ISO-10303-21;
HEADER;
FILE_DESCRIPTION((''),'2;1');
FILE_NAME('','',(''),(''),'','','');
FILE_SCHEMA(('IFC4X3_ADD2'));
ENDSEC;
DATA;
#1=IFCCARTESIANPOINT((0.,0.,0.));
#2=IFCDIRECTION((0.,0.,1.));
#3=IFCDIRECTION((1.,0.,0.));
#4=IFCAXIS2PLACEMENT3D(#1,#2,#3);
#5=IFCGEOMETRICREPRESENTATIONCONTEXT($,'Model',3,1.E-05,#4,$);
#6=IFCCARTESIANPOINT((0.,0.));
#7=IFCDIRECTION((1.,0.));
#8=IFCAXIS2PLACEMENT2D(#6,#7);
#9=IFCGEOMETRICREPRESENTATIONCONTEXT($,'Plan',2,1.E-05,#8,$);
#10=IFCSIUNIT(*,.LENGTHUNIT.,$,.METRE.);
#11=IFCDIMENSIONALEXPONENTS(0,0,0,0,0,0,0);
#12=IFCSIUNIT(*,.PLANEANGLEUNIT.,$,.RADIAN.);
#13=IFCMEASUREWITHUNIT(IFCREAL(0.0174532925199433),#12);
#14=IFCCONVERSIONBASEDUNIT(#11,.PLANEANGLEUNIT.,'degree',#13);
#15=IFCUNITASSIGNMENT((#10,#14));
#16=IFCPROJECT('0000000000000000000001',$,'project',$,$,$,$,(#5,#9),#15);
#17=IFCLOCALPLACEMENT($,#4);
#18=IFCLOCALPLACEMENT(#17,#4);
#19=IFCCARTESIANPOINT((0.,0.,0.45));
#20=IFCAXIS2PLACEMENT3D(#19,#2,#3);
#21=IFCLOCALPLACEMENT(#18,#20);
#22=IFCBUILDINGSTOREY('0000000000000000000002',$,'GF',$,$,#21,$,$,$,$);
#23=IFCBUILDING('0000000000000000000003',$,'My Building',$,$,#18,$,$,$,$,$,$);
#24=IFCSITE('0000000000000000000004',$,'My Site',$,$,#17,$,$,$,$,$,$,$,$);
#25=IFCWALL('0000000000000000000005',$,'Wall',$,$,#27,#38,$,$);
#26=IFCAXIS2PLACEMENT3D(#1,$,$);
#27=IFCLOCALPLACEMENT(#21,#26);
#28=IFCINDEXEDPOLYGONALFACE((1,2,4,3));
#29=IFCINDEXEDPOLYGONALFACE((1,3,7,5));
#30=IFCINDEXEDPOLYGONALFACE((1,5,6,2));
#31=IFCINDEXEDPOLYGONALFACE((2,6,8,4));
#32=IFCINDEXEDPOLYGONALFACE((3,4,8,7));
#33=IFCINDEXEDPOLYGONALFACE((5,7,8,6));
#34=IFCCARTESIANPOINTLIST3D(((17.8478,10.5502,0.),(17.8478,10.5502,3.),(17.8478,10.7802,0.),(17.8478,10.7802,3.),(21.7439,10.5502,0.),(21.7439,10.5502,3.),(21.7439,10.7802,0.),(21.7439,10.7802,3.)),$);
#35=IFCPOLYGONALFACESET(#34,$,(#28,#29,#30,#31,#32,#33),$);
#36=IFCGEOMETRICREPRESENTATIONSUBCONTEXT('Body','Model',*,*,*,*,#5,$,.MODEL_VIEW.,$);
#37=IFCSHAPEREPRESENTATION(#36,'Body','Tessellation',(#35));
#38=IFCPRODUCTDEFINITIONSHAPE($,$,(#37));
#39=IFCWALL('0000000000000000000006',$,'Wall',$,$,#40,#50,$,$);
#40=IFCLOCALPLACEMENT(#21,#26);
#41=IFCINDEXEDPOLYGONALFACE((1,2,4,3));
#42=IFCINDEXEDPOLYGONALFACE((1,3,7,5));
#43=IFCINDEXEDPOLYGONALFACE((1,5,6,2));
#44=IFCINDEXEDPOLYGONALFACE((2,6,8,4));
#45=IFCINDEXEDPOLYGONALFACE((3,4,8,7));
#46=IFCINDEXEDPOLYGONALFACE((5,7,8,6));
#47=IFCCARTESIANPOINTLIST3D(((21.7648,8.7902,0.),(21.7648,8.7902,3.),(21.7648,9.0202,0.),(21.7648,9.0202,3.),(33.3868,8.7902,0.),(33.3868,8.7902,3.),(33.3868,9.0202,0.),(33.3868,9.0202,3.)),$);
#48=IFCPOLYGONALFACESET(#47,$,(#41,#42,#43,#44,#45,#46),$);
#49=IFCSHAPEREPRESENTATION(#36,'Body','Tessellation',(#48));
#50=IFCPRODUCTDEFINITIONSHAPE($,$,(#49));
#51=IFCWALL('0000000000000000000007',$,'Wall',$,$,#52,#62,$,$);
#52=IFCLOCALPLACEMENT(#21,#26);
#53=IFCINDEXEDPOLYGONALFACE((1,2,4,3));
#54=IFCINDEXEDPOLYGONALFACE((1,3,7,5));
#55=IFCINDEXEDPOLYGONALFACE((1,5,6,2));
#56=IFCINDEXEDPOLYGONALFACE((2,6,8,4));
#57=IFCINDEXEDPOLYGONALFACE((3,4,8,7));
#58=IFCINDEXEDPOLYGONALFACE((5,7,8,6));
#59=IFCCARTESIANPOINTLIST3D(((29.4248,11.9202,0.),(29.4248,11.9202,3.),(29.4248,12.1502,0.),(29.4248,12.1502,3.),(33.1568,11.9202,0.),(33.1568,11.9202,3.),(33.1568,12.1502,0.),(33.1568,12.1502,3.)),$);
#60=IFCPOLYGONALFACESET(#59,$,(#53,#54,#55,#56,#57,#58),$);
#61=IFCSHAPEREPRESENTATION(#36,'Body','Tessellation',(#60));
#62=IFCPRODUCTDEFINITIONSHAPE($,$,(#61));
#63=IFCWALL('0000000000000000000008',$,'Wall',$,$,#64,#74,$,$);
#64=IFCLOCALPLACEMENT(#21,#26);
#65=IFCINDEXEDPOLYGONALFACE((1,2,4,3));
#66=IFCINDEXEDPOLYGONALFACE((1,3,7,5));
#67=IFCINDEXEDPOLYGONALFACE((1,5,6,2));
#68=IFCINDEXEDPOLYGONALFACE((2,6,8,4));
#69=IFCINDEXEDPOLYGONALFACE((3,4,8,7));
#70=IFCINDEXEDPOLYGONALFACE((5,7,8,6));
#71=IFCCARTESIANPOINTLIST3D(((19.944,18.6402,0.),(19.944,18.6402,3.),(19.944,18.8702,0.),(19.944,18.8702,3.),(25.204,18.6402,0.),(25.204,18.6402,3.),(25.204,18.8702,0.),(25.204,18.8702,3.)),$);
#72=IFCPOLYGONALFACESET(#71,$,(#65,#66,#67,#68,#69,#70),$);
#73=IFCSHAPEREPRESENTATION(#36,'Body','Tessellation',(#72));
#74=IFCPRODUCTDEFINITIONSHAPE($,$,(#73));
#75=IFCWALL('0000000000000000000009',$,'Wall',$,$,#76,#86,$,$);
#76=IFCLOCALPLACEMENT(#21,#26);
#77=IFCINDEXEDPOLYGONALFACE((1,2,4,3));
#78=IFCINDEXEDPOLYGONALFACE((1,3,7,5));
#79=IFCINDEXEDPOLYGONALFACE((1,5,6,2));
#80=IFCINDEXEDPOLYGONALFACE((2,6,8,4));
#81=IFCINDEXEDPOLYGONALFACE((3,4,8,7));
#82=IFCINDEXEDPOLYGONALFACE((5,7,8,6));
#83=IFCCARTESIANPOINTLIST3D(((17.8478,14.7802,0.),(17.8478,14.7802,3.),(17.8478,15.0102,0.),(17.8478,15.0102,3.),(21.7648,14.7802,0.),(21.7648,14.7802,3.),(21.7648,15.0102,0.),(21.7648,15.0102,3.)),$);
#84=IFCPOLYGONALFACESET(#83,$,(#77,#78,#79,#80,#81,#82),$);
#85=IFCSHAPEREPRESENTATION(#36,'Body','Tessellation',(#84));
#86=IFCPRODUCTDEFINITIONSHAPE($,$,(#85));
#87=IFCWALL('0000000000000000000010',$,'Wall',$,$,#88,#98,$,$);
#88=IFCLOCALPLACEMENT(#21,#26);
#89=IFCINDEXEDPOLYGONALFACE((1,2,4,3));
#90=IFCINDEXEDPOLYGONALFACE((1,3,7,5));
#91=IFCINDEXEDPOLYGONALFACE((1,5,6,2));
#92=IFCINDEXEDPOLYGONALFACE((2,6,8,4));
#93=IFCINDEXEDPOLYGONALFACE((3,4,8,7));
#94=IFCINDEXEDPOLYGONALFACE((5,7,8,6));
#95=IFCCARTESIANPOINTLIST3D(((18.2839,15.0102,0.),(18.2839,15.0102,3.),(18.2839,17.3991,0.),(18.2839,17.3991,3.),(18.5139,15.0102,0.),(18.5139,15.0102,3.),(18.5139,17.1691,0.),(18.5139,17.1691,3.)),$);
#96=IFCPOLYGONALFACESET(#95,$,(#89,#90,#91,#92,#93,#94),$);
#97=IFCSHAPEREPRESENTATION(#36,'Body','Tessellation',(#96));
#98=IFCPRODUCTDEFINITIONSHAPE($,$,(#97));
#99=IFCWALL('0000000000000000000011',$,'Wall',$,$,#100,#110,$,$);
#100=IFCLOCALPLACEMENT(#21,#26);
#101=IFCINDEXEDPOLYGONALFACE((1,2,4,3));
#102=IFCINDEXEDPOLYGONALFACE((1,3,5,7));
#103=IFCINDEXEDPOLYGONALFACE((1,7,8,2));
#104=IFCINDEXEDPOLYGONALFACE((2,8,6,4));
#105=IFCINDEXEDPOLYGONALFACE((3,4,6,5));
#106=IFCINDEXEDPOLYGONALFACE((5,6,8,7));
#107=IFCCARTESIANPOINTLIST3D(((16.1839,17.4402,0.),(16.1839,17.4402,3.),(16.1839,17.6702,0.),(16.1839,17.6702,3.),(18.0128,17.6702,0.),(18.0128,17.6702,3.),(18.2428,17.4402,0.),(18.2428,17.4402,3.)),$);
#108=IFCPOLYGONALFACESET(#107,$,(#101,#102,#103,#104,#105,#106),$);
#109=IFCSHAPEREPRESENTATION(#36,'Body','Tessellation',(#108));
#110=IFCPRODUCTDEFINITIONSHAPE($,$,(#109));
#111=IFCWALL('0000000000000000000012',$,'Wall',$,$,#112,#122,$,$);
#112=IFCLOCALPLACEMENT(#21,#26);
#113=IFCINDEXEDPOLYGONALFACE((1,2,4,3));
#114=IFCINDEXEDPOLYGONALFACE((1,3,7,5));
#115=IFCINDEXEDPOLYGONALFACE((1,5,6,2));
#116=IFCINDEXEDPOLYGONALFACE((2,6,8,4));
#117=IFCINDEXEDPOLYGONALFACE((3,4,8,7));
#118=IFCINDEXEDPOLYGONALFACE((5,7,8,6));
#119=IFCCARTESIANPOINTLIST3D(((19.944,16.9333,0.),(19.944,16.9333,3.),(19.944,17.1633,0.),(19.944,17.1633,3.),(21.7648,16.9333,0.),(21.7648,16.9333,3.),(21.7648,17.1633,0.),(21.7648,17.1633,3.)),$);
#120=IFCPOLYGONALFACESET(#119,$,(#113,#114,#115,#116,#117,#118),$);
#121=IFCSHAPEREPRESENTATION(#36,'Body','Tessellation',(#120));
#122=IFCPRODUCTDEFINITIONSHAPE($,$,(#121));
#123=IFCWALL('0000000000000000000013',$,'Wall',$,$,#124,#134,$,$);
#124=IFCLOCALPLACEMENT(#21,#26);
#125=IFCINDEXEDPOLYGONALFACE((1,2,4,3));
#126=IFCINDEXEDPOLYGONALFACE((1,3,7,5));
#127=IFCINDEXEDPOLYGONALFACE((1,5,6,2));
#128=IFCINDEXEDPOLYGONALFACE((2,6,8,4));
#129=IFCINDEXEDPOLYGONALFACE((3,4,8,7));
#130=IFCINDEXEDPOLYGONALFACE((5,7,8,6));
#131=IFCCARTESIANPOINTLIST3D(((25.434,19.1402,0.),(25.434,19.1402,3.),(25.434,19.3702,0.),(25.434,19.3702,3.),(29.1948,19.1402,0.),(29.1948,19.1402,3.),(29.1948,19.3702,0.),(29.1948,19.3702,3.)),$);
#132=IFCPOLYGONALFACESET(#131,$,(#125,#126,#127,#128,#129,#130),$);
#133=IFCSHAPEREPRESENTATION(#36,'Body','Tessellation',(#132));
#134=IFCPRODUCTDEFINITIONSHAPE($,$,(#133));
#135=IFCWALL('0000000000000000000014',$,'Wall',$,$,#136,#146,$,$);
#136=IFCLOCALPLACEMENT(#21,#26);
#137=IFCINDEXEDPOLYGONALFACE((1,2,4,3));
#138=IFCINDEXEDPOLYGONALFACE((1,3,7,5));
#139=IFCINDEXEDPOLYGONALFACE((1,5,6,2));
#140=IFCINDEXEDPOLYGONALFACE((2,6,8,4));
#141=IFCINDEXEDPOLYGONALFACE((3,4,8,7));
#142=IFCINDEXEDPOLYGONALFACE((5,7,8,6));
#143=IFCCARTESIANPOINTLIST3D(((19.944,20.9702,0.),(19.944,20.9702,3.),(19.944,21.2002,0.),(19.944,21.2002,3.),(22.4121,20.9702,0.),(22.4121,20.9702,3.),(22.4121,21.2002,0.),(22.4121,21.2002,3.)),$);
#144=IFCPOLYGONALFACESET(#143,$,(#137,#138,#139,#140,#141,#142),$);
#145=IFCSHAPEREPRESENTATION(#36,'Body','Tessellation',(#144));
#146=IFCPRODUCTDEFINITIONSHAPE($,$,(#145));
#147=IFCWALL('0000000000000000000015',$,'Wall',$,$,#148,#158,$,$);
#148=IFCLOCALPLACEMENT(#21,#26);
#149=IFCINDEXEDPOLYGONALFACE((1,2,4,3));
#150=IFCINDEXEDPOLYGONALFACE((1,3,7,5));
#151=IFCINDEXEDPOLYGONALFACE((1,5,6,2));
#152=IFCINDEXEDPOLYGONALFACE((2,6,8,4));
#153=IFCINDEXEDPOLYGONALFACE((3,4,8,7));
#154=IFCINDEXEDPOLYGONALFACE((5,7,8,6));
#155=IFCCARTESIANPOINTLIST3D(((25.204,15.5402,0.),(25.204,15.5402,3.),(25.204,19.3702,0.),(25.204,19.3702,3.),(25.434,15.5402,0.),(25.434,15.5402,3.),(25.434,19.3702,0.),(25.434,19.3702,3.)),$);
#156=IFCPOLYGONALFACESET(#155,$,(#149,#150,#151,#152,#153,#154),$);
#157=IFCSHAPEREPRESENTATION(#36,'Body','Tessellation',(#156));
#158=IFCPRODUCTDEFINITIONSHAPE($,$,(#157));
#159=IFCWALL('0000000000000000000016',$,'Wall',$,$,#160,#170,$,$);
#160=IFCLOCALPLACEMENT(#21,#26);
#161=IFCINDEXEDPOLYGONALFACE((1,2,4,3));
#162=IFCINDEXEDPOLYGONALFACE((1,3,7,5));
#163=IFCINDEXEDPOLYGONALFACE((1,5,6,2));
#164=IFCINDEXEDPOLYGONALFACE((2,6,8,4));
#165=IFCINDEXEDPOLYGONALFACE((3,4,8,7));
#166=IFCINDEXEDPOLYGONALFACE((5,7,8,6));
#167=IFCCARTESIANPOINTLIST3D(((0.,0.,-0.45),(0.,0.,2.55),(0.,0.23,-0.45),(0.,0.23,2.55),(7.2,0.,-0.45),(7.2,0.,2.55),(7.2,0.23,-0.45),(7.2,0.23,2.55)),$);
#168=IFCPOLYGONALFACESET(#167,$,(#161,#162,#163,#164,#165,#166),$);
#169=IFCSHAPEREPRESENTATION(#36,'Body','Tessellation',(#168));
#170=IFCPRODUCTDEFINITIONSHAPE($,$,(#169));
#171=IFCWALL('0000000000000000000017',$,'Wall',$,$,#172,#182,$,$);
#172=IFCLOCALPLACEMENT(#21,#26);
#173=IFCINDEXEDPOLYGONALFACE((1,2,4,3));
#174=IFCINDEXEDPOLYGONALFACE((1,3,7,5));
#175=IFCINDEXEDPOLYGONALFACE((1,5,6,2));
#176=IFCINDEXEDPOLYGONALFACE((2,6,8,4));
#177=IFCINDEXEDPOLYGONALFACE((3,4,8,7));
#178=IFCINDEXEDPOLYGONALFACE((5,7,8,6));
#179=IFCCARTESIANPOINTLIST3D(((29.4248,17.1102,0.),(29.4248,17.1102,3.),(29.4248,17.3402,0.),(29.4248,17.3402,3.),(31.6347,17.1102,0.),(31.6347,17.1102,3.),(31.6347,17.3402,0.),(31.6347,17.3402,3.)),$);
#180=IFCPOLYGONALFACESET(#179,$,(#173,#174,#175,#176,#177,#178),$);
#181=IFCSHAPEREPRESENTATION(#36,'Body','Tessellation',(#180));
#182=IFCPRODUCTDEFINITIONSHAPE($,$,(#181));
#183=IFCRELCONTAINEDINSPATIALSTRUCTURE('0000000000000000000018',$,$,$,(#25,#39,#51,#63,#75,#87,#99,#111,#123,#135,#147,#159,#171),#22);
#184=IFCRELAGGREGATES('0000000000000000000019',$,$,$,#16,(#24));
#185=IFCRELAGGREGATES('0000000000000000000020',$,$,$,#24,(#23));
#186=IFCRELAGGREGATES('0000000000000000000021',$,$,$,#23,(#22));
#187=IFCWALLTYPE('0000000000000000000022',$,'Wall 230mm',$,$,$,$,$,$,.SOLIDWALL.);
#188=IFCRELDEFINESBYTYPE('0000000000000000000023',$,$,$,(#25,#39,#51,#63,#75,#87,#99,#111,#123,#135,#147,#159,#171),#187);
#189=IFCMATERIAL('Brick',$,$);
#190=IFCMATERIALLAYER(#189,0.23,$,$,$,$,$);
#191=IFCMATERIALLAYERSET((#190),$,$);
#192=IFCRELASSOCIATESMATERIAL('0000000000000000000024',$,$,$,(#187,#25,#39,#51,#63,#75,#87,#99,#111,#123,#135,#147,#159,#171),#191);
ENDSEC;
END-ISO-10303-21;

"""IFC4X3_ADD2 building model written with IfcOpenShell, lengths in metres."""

from ifc_helpers import new_model, entity, si_unit, converted_unit, frame, origin_with_axes, origin_2d_with_axis, place, context, subcontext, project, spatial, indexed_curve, outline, extrude, clip, halfspace, material, layer, layer_set, layer_usage, type_object, element, save


model = new_model("IFC4X3_ADD2")

# Units and contexts
model_context = context("Model", 3, precision=1e-05, world=origin_with_axes())
plan_context = context("Plan", 2, precision=1e-05, world=origin_2d_with_axis())
body_context = subcontext(model_context, "Body", "Model", "MODEL_VIEW")
ifc_project = project(units=[si_unit("LENGTHUNIT", "METRE"), converted_unit("PLANEANGLEUNIT", "degree", entity("IfcReal", 0.0174532925199433), si_unit("PLANEANGLEUNIT", "RADIAN"), dimensions=[0, 0, 0, 0, 0, 0, 0])], contexts=[model_context, plan_context])

# Site, building, storey
site_placement = place(None, origin_with_axes())
site = spatial("IfcSite", under=ifc_project, at=site_placement, Name="My Site")
building_placement = place(site_placement, origin_with_axes())
building = spatial("IfcBuilding", under=site, at=building_placement, Name="My Building")
storey_placement = place(building_placement, frame((0.0, 0.0, 0.45), z_axis=(0.0, 0.0, 1.0), x_axis=(1.0, 0.0, 0.0)))
storey = spatial("IfcBuildingStorey", under=building, at=storey_placement, Name="GF")

# Walls
ifc_material_1 = material(Name="Brick")
ifc_layer_1 = layer(ifc_material_1, 0.23)
ifc_layer_set_1 = layer_set([ifc_layer_1])
wall_type_1 = type_object("IfcWallType", Name="Wall 230mm", PredefinedType="SOLIDWALL", material=ifc_layer_set_1)
ifc_layer_usage_1 = layer_usage(ifc_layer_set_1, "AXIS2", "POSITIVE", 0.0)
wall_1_placement = place(storey_placement, frame((21.7439, 10.7802, 0.0), z_axis=(0.0, 0.0, 1.0), x_axis=(-1.0, 0.0, 0.0)))
element("IfcWall", 1, at=wall_1_placement, inside=storey, type_object=wall_type_1, material=ifc_layer_usage_1, Name="Wall", context=body_context, shape_type="SweptSolid", body=[
    extrude(outline(indexed_curve([(0.0, 0.0), (0.0, 0.23), (3.8962, 0.23), (3.8962, 0.0), (0.0, 0.0)], self_intersect=False)), origin_with_axes(), (0.0, 0.0, 1.0), 3.0),
])
ifc_layer_usage_2 = layer_usage(ifc_layer_set_1, "AXIS2", "POSITIVE", 0.0)
wall_2_placement = place(storey_placement, frame((33.3868, 9.0202, 0.0), z_axis=(0.0, 0.0, 1.0), x_axis=(-1.0, 0.0, 0.0)))
element("IfcWall", 2, at=wall_2_placement, inside=storey, type_object=wall_type_1, material=ifc_layer_usage_2, Name="Wall", context=body_context, shape_type="SweptSolid", body=[
    extrude(outline(indexed_curve([(0.0, 0.0), (0.0, 0.23), (11.622, 0.23), (11.622, 0.0), (0.0, 0.0)], self_intersect=False)), origin_with_axes(), (0.0, 0.0, 1.0), 3.0),
])
ifc_layer_usage_3 = layer_usage(ifc_layer_set_1, "AXIS2", "POSITIVE", 0.0)
wall_3_placement = place(storey_placement, frame((33.1568, 12.1502, 0.0), z_axis=(0.0, 0.0, 1.0), x_axis=(-1.0, 0.0, 0.0)))
element("IfcWall", 3, at=wall_3_placement, inside=storey, type_object=wall_type_1, material=ifc_layer_usage_3, Name="Wall", context=body_context, shape_type="SweptSolid", body=[
    extrude(outline(indexed_curve([(0.0, 0.0), (0.0, 0.23), (3.732, 0.23), (3.732, 0.0), (0.0, 0.0)], self_intersect=False)), origin_with_axes(), (0.0, 0.0, 1.0), 3.0),
])
ifc_layer_usage_4 = layer_usage(ifc_layer_set_1, "AXIS2", "POSITIVE", 0.0)
wall_4_placement = place(storey_placement, frame((25.204, 18.8702, 0.0), z_axis=(0.0, 0.0, 1.0), x_axis=(-1.0, 0.0, 0.0)))
element("IfcWall", 4, at=wall_4_placement, inside=storey, type_object=wall_type_1, material=ifc_layer_usage_4, Name="Wall", context=body_context, shape_type="SweptSolid", body=[
    extrude(outline(indexed_curve([(0.0, 0.0), (0.0, 0.23), (5.26, 0.23), (5.26, 0.0), (0.0, 0.0)], self_intersect=False)), origin_with_axes(), (0.0, 0.0, 1.0), 3.0),
])
ifc_layer_usage_5 = layer_usage(ifc_layer_set_1, "AXIS2", "POSITIVE", 0.0)
wall_5_placement = place(storey_placement, frame((21.7648, 15.0102, 0.0), z_axis=(0.0, 0.0, 1.0), x_axis=(-1.0, 0.0, 0.0)))
element("IfcWall", 5, at=wall_5_placement, inside=storey, type_object=wall_type_1, material=ifc_layer_usage_5, Name="Wall", context=body_context, shape_type="SweptSolid", body=[
    extrude(outline(indexed_curve([(0.0, 0.0), (0.0, 0.23), (3.917, 0.23), (3.917, 0.0), (0.0, 0.0)], self_intersect=False)), origin_with_axes(), (0.0, 0.0, 1.0), 3.0),
])
ifc_layer_usage_6 = layer_usage(ifc_layer_set_1, "AXIS2", "POSITIVE", 0.0)
wall_6_placement = place(storey_placement, frame((18.5139, 15.0102, 0.0), z_axis=(0.0, 0.0, 1.0), x_axis=(0.000001, 1.0, 0.0)))
element("IfcWall", 6, at=wall_6_placement, inside=storey, type_object=wall_type_1, material=ifc_layer_usage_6, Name="Wall", context=body_context, shape_type="Clipping", body=[
    clip(extrude(outline(indexed_curve([(0.0, 0.0), (0.0, 0.23), (2.3889, 0.23), (2.3889, 0.0), (0.0, 0.0)], self_intersect=False)), origin_with_axes(), (0.0, 0.0, 1.0), 3.0), halfspace(frame((2.1589, 0.0, 0.0), z_axis=(0.689993, -0.689998, 0.0), x_axis=(-0.707109, -0.707104, 0.0)), False)),
])
ifc_layer_usage_7 = layer_usage(ifc_layer_set_1, "AXIS2", "POSITIVE", 0.0)
wall_7_placement = place(storey_placement, frame((18.2428, 17.6702, 0.0), z_axis=(0.0, 0.0, 1.0), x_axis=(-1.0, 0.0, 0.0)))
element("IfcWall", 7, at=wall_7_placement, inside=storey, type_object=wall_type_1, material=ifc_layer_usage_7, Name="Wall", context=body_context, shape_type="Clipping", body=[
    clip(extrude(outline(indexed_curve([(0.0, 0.0), (0.0, 0.23), (2.0589, 0.23), (2.0589, 0.0), (0.0, 0.0)], self_intersect=False)), origin_with_axes(), (0.0, 0.0, 1.0), 3.0), halfspace(frame((0.23, 0.0, 0.0), z_axis=(-0.689993, -0.689999, 0.0), x_axis=(-0.70711, 0.707104, 0.0)), False)),
])
ifc_layer_usage_8 = layer_usage(ifc_layer_set_1, "AXIS2", "POSITIVE", 0.0)
wall_8_placement = place(storey_placement, frame((21.7648, 17.1633, 0.0), z_axis=(0.0, 0.0, 1.0), x_axis=(-1.0, 0.0, 0.0)))
element("IfcWall", 8, at=wall_8_placement, inside=storey, type_object=wall_type_1, material=ifc_layer_usage_8, Name="Wall", context=body_context, shape_type="SweptSolid", body=[
    extrude(outline(indexed_curve([(0.0, 0.0), (0.0, 0.23), (1.8208, 0.23), (1.8208, 0.0), (0.0, 0.0)], self_intersect=False)), origin_with_axes(), (0.0, 0.0, 1.0), 3.0),
])
ifc_layer_usage_9 = layer_usage(ifc_layer_set_1, "AXIS2", "POSITIVE", 0.0)
wall_9_placement = place(storey_placement, frame((29.1948, 19.3702, 0.0), z_axis=(0.0, 0.0, 1.0), x_axis=(-1.0, 0.0, 0.0)))
element("IfcWall", 9, at=wall_9_placement, inside=storey, type_object=wall_type_1, material=ifc_layer_usage_9, Name="Wall", context=body_context, shape_type="SweptSolid", body=[
    extrude(outline(indexed_curve([(0.0, 0.0), (0.0, 0.23), (3.7608, 0.23), (3.7608, 0.0), (0.0, 0.0)], self_intersect=False)), origin_with_axes(), (0.0, 0.0, 1.0), 3.0),
])
ifc_layer_usage_10 = layer_usage(ifc_layer_set_1, "AXIS2", "POSITIVE", 0.0)
wall_10_placement = place(storey_placement, frame((22.4121, 21.2002, 0.0), z_axis=(0.0, 0.0, 1.0), x_axis=(-1.0, 0.0, 0.0)))
element("IfcWall", 10, at=wall_10_placement, inside=storey, type_object=wall_type_1, material=ifc_layer_usage_10, Name="Wall", context=body_context, shape_type="SweptSolid", body=[
    extrude(outline(indexed_curve([(0.0, 0.0), (0.0, 0.23), (2.4681, 0.23), (2.4681, 0.0), (0.0, 0.0)], self_intersect=False)), origin_with_axes(), (0.0, 0.0, 1.0), 3.0),
])
ifc_layer_usage_11 = layer_usage(ifc_layer_set_1, "AXIS2", "POSITIVE", 0.0)
wall_11_placement = place(storey_placement, frame((25.434, 15.5402, 0.0), z_axis=(0.0, 0.0, 1.0), x_axis=(0.000001, 1.0, 0.0)))
element("IfcWall", 11, at=wall_11_placement, inside=storey, type_object=wall_type_1, material=ifc_layer_usage_11, Name="Wall", context=body_context, shape_type="SweptSolid", body=[
    extrude(outline(indexed_curve([(0.0, 0.0), (0.0, 0.23), (3.83, 0.23), (3.83, 0.0), (0.0, 0.0)], self_intersect=False)), origin_with_axes(), (0.0, 0.0, 1.0), 3.0),
])
ifc_layer_usage_12 = layer_usage(ifc_layer_set_1, "AXIS2", "POSITIVE", 0.0)
wall_12_placement = place(storey_placement, frame((0.0, 0.0, -0.45), z_axis=(0.0, 0.0, 1.0), x_axis=(1.0, 0.0, 0.0)))
element("IfcWall", 12, at=wall_12_placement, inside=storey, type_object=wall_type_1, material=ifc_layer_usage_12, Name="Wall", context=body_context, shape_type="SweptSolid", body=[
    extrude(outline(indexed_curve([(0.0, 0.0), (0.0, 0.23), (7.2, 0.23), (7.2, 0.0), (0.0, 0.0)], self_intersect=False)), origin_with_axes(), (0.0, 0.0, 1.0), 3.0),
])
ifc_layer_usage_13 = layer_usage(ifc_layer_set_1, "AXIS2", "POSITIVE", 0.0)
wall_13_placement = place(storey_placement, frame((31.6347, 17.3402, 0.0), z_axis=(0.0, 0.0, 1.0), x_axis=(-1.0, 0.0, 0.0)))
element("IfcWall", 13, at=wall_13_placement, inside=storey, type_object=wall_type_1, material=ifc_layer_usage_13, Name="Wall", context=body_context, shape_type="SweptSolid", body=[
    extrude(outline(indexed_curve([(0.0, 0.0), (0.0, 0.23), (2.21, 0.23), (2.21, 0.0), (0.0, 0.0)], self_intersect=False)), origin_with_axes(), (0.0, 0.0, 1.0), 3.0),
])

save(model, "model.ifc")
